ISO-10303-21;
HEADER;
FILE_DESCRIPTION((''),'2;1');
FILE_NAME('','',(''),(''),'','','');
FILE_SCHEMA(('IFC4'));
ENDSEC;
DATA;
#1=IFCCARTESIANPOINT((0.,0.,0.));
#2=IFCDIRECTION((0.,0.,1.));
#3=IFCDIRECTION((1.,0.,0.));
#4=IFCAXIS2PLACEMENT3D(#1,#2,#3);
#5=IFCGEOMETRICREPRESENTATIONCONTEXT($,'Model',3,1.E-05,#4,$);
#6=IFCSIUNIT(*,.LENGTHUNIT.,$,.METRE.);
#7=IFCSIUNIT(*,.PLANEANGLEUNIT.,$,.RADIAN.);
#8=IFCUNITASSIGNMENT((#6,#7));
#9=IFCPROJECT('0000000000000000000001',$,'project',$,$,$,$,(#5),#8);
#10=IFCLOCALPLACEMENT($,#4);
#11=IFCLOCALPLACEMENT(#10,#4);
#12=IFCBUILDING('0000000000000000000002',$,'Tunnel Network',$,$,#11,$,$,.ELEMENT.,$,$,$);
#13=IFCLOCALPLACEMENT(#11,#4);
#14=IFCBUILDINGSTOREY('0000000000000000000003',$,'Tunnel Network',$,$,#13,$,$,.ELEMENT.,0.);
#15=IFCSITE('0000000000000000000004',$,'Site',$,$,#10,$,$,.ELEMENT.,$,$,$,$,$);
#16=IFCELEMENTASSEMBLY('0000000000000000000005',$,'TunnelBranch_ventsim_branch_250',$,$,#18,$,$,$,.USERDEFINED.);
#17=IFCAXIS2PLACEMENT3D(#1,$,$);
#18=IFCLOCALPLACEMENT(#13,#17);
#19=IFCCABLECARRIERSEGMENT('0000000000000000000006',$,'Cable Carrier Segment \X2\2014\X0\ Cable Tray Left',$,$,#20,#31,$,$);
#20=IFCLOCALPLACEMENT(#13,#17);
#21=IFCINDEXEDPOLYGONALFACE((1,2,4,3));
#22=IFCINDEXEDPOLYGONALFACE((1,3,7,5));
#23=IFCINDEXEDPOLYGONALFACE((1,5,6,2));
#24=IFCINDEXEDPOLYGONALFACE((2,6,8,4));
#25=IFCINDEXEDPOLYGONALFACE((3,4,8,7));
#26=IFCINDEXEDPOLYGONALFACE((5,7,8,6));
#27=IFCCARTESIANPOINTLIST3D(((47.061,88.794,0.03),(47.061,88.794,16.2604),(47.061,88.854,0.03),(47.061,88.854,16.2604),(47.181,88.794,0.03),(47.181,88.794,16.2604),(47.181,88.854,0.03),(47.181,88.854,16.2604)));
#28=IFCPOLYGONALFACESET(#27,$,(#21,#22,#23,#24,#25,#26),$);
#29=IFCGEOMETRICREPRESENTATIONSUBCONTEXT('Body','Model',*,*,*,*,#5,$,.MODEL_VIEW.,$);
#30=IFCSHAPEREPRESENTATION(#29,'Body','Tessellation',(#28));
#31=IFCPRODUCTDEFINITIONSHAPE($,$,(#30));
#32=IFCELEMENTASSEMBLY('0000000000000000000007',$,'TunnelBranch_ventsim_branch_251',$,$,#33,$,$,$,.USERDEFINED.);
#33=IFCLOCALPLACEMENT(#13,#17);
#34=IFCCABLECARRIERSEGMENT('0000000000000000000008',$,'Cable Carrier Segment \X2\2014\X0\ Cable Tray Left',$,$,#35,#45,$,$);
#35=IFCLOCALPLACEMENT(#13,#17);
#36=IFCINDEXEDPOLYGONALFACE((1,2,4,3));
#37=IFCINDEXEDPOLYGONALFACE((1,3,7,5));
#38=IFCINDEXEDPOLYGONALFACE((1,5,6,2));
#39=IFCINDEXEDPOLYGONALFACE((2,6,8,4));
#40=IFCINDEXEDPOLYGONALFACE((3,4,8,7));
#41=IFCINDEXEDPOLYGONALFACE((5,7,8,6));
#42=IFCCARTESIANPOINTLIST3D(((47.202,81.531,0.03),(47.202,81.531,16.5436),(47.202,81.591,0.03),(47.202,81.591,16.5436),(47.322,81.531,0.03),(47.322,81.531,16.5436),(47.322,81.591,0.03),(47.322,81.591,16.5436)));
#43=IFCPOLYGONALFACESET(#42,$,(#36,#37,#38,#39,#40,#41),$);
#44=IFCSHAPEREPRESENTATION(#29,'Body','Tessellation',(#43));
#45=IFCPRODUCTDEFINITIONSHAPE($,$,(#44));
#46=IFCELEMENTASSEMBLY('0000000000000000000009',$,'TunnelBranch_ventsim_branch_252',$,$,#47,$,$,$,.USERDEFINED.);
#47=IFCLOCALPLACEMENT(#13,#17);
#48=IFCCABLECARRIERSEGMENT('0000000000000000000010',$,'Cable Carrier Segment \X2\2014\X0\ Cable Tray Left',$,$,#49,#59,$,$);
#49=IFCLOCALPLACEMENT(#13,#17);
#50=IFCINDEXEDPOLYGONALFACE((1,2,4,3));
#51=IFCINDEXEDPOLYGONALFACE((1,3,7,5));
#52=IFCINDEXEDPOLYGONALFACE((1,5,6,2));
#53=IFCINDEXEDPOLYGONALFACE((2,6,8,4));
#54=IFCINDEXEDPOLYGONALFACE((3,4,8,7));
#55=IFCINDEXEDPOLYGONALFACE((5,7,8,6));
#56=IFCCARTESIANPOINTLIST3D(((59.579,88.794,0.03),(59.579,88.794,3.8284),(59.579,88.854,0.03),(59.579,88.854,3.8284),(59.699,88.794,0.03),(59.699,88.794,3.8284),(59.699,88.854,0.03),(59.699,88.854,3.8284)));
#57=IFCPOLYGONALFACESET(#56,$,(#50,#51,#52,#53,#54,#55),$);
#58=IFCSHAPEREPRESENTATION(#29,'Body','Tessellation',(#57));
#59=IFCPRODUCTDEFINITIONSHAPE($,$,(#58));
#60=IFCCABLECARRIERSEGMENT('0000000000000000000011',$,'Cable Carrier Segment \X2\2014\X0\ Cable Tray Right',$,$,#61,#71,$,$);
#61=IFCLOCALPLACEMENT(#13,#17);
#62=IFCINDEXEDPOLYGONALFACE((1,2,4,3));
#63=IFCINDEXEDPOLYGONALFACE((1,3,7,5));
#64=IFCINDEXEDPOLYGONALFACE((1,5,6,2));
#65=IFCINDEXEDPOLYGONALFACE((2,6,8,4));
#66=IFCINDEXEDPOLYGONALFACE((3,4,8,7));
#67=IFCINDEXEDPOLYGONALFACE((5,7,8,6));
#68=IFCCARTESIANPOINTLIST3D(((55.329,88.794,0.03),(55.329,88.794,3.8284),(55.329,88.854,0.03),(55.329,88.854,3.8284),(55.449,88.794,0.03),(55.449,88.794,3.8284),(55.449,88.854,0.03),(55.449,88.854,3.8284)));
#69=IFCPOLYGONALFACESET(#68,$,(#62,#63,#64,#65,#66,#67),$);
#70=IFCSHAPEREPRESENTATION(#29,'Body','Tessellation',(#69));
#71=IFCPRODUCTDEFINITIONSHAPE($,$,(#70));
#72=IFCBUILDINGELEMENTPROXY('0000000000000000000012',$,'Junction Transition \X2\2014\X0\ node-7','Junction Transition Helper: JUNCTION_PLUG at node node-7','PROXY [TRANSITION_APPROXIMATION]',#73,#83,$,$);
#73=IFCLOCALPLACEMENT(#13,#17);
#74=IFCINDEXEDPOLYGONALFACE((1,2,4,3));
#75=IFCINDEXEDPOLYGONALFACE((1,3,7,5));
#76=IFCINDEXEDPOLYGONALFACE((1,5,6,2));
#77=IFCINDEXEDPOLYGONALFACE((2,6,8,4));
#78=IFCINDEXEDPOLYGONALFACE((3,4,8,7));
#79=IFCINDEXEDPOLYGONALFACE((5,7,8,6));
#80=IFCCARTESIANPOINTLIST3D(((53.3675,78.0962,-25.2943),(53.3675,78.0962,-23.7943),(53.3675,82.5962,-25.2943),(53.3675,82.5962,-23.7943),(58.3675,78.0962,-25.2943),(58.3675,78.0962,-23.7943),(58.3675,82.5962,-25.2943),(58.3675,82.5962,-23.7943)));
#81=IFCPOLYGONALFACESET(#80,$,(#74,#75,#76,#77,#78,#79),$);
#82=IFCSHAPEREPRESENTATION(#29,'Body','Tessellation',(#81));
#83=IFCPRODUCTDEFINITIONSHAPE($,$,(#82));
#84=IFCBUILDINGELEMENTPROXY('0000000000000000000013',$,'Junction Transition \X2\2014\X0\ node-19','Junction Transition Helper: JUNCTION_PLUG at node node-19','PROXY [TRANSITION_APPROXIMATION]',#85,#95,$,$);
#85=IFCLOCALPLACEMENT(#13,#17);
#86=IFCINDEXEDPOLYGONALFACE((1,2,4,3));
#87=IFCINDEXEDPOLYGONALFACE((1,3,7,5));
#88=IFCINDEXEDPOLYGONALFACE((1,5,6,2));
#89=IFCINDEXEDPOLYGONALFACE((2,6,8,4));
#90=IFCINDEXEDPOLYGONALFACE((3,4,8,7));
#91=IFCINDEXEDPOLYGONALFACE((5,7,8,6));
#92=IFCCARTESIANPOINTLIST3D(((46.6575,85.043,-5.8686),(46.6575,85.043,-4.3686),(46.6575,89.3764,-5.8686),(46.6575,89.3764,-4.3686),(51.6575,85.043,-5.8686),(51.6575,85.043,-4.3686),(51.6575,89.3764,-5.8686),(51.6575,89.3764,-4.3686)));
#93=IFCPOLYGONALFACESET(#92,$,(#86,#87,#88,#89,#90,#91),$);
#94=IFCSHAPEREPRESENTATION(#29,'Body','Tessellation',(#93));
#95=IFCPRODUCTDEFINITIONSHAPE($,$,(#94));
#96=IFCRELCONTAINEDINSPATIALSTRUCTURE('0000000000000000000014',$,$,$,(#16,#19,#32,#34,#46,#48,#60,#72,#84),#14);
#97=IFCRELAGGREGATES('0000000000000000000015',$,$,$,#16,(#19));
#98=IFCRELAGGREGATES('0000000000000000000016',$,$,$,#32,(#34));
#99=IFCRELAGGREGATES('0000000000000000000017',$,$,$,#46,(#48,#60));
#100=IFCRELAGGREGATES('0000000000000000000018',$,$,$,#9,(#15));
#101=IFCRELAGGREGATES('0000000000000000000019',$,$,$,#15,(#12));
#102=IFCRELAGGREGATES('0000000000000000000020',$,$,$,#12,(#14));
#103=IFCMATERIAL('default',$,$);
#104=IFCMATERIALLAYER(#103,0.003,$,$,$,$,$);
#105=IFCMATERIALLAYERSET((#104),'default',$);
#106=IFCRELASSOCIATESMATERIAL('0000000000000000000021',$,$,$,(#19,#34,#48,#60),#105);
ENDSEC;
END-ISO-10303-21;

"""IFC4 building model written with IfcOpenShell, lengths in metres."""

from ifc_helpers import new_model, si_unit, frame, origin_with_axes, origin_2d_with_axis, place, context, subcontext, project, spatial, rectangle, extrude, material, layer, layer_set, layer_usage, element, aggregate, save


model = new_model("IFC4")

# Units and contexts
model_context = context("Model", 3, precision=1e-05, world=origin_with_axes())
body_context = subcontext(model_context, "Body", "Model", "MODEL_VIEW")
ifc_project = project(units=[si_unit("LENGTHUNIT", "METRE"), si_unit("PLANEANGLEUNIT", "RADIAN")], contexts=[model_context])

# Site, building, storey
site_placement = place(None, origin_with_axes())
site = spatial("IfcSite", under=ifc_project, at=site_placement, Name="Site", CompositionType="ELEMENT")
building_placement = place(site_placement, origin_with_axes())
building = spatial("IfcBuilding", under=site, at=building_placement, Name="Tunnel Network", CompositionType="ELEMENT")
storey_placement = place(building_placement, origin_with_axes())
storey = spatial("IfcBuildingStorey", under=building, at=storey_placement, Name="Tunnel Network", CompositionType="ELEMENT", Elevation=0.0)

# Shared definitions
ifc_material_1 = material(Name="default")
ifc_layer_1 = layer(ifc_material_1, 0.003)
ifc_layer_set_1 = layer_set([ifc_layer_1], Name="default")

# Element assemblies, cable carrier segments
assembly_1_placement = place(storey_placement, frame((44.996, 89.724, 1.0), z_axis=(0.0, 1.0, 0.0), x_axis=(-1.0, 0.0, 0.0)))
assembly_1 = element("IfcElementAssembly", 1, at=assembly_1_placement, inside=storey, Name="TunnelBranch_ventsim_branch_250", PredefinedType="USERDEFINED")
ifc_layer_usage_1 = layer_usage(ifc_layer_set_1, "AXIS2", "POSITIVE", 0.0)
cable_carrier_segment_1_placement = place(storey_placement, frame((47.121, 88.824, 0.03), z_axis=(0.0, 0.0, 1.0), x_axis=(-1.0, 0.0, 0.0)))
cable_carrier_segment_1 = element("IfcCableCarrierSegment", 2, at=cable_carrier_segment_1_placement, inside=storey, material=ifc_layer_usage_1, Name="Cable Carrier Segment — Cable Tray Left", context=body_context, shape_type="SweptSolid", body=[
    extrude(rectangle(XDim=0.12, YDim=0.06, at=origin_2d_with_axis()), origin_with_axes(), (0.0, 0.0, 1.0), 16.2304),
])
aggregate(assembly_1, [cable_carrier_segment_1])
assembly_2_placement = place(storey_placement, frame((45.137, 82.461, 1.0), z_axis=(0.0, 1.0, 0.0), x_axis=(-1.0, 0.0, 0.0)))
assembly_2 = element("IfcElementAssembly", 3, at=assembly_2_placement, inside=storey, Name="TunnelBranch_ventsim_branch_251", PredefinedType="USERDEFINED")
ifc_layer_usage_2 = layer_usage(ifc_layer_set_1, "AXIS2", "POSITIVE", 0.0)
cable_carrier_segment_2_placement = place(storey_placement, frame((47.262, 81.561, 0.03), z_axis=(0.0, 0.0, 1.0), x_axis=(-1.0, 0.0, 0.0)))
cable_carrier_segment_2 = element("IfcCableCarrierSegment", 4, at=cable_carrier_segment_2_placement, inside=storey, material=ifc_layer_usage_2, Name="Cable Carrier Segment — Cable Tray Left", context=body_context, shape_type="SweptSolid", body=[
    extrude(rectangle(XDim=0.12, YDim=0.06, at=origin_2d_with_axis()), origin_with_axes(), (0.0, 0.0, 1.0), 16.5136),
])
aggregate(assembly_2, [cable_carrier_segment_2])

# Element assembly, cable carrier segments
assembly_3_placement = place(storey_placement, frame((57.514, 89.724, 1.0), z_axis=(0.0, 1.0, 0.0), x_axis=(-1.0, 0.0, 0.0)))
assembly_3 = element("IfcElementAssembly", 5, at=assembly_3_placement, inside=storey, Name="TunnelBranch_ventsim_branch_252", PredefinedType="USERDEFINED")
ifc_layer_usage_3 = layer_usage(ifc_layer_set_1, "AXIS2", "POSITIVE", 0.0)
cable_carrier_segment_3_placement = place(storey_placement, frame((59.639, 88.824, 0.03), z_axis=(0.0, 0.0, 1.0), x_axis=(-1.0, 0.0, 0.0)))
cable_carrier_segment_3 = element("IfcCableCarrierSegment", 6, at=cable_carrier_segment_3_placement, inside=storey, material=ifc_layer_usage_3, Name="Cable Carrier Segment — Cable Tray Left", context=body_context, shape_type="SweptSolid", body=[
    extrude(rectangle(XDim=0.12, YDim=0.06, at=origin_2d_with_axis()), origin_with_axes(), (0.0, 0.0, 1.0), 3.7984),
])
ifc_layer_usage_4 = layer_usage(ifc_layer_set_1, "AXIS2", "POSITIVE", 0.0)
cable_carrier_segment_4_placement = place(storey_placement, frame((55.389, 88.824, 0.03), z_axis=(0.0, 0.0, 1.0), x_axis=(-1.0, 0.0, 0.0)))
cable_carrier_segment_4 = element("IfcCableCarrierSegment", 7, at=cable_carrier_segment_4_placement, inside=storey, material=ifc_layer_usage_4, Name="Cable Carrier Segment — Cable Tray Right", context=body_context, shape_type="SweptSolid", body=[
    extrude(rectangle(XDim=0.12, YDim=0.06, at=origin_2d_with_axis()), origin_with_axes(), (0.0, 0.0, 1.0), 3.7984),
])
aggregate(assembly_3, [cable_carrier_segment_3, cable_carrier_segment_4])

# Building element proxies
proxy_1_placement = place(storey_placement, frame((55.8675, 80.3462, -25.2943), z_axis=(0.0, 0.0, 1.0), x_axis=(1.0, 0.0, 0.0)))
element("IfcBuildingElementProxy", 8, at=proxy_1_placement, inside=storey, Name="Junction Transition — node-7", Description="Junction Transition Helper: JUNCTION_PLUG at node node-7", ObjectType="PROXY [TRANSITION_APPROXIMATION]", context=body_context, shape_type="SweptSolid", body=[
    extrude(rectangle(XDim=5.0, YDim=4.5, at=origin_2d_with_axis()), origin_with_axes(), (0.0, 0.0, 1.0), 1.5),
])
proxy_2_placement = place(storey_placement, frame((49.1575, 87.2097, -5.8686), z_axis=(0.0, 0.0, 1.0), x_axis=(1.0, 0.0, 0.0)))
element("IfcBuildingElementProxy", 9, at=proxy_2_placement, inside=storey, Name="Junction Transition — node-19", Description="Junction Transition Helper: JUNCTION_PLUG at node node-19", ObjectType="PROXY [TRANSITION_APPROXIMATION]", context=body_context, shape_type="SweptSolid", body=[
    extrude(rectangle(XDim=5.0, YDim=4.3333, at=origin_2d_with_axis()), origin_with_axes(), (0.0, 0.0, 1.0), 1.5),
])

save(model, "model.ifc")
